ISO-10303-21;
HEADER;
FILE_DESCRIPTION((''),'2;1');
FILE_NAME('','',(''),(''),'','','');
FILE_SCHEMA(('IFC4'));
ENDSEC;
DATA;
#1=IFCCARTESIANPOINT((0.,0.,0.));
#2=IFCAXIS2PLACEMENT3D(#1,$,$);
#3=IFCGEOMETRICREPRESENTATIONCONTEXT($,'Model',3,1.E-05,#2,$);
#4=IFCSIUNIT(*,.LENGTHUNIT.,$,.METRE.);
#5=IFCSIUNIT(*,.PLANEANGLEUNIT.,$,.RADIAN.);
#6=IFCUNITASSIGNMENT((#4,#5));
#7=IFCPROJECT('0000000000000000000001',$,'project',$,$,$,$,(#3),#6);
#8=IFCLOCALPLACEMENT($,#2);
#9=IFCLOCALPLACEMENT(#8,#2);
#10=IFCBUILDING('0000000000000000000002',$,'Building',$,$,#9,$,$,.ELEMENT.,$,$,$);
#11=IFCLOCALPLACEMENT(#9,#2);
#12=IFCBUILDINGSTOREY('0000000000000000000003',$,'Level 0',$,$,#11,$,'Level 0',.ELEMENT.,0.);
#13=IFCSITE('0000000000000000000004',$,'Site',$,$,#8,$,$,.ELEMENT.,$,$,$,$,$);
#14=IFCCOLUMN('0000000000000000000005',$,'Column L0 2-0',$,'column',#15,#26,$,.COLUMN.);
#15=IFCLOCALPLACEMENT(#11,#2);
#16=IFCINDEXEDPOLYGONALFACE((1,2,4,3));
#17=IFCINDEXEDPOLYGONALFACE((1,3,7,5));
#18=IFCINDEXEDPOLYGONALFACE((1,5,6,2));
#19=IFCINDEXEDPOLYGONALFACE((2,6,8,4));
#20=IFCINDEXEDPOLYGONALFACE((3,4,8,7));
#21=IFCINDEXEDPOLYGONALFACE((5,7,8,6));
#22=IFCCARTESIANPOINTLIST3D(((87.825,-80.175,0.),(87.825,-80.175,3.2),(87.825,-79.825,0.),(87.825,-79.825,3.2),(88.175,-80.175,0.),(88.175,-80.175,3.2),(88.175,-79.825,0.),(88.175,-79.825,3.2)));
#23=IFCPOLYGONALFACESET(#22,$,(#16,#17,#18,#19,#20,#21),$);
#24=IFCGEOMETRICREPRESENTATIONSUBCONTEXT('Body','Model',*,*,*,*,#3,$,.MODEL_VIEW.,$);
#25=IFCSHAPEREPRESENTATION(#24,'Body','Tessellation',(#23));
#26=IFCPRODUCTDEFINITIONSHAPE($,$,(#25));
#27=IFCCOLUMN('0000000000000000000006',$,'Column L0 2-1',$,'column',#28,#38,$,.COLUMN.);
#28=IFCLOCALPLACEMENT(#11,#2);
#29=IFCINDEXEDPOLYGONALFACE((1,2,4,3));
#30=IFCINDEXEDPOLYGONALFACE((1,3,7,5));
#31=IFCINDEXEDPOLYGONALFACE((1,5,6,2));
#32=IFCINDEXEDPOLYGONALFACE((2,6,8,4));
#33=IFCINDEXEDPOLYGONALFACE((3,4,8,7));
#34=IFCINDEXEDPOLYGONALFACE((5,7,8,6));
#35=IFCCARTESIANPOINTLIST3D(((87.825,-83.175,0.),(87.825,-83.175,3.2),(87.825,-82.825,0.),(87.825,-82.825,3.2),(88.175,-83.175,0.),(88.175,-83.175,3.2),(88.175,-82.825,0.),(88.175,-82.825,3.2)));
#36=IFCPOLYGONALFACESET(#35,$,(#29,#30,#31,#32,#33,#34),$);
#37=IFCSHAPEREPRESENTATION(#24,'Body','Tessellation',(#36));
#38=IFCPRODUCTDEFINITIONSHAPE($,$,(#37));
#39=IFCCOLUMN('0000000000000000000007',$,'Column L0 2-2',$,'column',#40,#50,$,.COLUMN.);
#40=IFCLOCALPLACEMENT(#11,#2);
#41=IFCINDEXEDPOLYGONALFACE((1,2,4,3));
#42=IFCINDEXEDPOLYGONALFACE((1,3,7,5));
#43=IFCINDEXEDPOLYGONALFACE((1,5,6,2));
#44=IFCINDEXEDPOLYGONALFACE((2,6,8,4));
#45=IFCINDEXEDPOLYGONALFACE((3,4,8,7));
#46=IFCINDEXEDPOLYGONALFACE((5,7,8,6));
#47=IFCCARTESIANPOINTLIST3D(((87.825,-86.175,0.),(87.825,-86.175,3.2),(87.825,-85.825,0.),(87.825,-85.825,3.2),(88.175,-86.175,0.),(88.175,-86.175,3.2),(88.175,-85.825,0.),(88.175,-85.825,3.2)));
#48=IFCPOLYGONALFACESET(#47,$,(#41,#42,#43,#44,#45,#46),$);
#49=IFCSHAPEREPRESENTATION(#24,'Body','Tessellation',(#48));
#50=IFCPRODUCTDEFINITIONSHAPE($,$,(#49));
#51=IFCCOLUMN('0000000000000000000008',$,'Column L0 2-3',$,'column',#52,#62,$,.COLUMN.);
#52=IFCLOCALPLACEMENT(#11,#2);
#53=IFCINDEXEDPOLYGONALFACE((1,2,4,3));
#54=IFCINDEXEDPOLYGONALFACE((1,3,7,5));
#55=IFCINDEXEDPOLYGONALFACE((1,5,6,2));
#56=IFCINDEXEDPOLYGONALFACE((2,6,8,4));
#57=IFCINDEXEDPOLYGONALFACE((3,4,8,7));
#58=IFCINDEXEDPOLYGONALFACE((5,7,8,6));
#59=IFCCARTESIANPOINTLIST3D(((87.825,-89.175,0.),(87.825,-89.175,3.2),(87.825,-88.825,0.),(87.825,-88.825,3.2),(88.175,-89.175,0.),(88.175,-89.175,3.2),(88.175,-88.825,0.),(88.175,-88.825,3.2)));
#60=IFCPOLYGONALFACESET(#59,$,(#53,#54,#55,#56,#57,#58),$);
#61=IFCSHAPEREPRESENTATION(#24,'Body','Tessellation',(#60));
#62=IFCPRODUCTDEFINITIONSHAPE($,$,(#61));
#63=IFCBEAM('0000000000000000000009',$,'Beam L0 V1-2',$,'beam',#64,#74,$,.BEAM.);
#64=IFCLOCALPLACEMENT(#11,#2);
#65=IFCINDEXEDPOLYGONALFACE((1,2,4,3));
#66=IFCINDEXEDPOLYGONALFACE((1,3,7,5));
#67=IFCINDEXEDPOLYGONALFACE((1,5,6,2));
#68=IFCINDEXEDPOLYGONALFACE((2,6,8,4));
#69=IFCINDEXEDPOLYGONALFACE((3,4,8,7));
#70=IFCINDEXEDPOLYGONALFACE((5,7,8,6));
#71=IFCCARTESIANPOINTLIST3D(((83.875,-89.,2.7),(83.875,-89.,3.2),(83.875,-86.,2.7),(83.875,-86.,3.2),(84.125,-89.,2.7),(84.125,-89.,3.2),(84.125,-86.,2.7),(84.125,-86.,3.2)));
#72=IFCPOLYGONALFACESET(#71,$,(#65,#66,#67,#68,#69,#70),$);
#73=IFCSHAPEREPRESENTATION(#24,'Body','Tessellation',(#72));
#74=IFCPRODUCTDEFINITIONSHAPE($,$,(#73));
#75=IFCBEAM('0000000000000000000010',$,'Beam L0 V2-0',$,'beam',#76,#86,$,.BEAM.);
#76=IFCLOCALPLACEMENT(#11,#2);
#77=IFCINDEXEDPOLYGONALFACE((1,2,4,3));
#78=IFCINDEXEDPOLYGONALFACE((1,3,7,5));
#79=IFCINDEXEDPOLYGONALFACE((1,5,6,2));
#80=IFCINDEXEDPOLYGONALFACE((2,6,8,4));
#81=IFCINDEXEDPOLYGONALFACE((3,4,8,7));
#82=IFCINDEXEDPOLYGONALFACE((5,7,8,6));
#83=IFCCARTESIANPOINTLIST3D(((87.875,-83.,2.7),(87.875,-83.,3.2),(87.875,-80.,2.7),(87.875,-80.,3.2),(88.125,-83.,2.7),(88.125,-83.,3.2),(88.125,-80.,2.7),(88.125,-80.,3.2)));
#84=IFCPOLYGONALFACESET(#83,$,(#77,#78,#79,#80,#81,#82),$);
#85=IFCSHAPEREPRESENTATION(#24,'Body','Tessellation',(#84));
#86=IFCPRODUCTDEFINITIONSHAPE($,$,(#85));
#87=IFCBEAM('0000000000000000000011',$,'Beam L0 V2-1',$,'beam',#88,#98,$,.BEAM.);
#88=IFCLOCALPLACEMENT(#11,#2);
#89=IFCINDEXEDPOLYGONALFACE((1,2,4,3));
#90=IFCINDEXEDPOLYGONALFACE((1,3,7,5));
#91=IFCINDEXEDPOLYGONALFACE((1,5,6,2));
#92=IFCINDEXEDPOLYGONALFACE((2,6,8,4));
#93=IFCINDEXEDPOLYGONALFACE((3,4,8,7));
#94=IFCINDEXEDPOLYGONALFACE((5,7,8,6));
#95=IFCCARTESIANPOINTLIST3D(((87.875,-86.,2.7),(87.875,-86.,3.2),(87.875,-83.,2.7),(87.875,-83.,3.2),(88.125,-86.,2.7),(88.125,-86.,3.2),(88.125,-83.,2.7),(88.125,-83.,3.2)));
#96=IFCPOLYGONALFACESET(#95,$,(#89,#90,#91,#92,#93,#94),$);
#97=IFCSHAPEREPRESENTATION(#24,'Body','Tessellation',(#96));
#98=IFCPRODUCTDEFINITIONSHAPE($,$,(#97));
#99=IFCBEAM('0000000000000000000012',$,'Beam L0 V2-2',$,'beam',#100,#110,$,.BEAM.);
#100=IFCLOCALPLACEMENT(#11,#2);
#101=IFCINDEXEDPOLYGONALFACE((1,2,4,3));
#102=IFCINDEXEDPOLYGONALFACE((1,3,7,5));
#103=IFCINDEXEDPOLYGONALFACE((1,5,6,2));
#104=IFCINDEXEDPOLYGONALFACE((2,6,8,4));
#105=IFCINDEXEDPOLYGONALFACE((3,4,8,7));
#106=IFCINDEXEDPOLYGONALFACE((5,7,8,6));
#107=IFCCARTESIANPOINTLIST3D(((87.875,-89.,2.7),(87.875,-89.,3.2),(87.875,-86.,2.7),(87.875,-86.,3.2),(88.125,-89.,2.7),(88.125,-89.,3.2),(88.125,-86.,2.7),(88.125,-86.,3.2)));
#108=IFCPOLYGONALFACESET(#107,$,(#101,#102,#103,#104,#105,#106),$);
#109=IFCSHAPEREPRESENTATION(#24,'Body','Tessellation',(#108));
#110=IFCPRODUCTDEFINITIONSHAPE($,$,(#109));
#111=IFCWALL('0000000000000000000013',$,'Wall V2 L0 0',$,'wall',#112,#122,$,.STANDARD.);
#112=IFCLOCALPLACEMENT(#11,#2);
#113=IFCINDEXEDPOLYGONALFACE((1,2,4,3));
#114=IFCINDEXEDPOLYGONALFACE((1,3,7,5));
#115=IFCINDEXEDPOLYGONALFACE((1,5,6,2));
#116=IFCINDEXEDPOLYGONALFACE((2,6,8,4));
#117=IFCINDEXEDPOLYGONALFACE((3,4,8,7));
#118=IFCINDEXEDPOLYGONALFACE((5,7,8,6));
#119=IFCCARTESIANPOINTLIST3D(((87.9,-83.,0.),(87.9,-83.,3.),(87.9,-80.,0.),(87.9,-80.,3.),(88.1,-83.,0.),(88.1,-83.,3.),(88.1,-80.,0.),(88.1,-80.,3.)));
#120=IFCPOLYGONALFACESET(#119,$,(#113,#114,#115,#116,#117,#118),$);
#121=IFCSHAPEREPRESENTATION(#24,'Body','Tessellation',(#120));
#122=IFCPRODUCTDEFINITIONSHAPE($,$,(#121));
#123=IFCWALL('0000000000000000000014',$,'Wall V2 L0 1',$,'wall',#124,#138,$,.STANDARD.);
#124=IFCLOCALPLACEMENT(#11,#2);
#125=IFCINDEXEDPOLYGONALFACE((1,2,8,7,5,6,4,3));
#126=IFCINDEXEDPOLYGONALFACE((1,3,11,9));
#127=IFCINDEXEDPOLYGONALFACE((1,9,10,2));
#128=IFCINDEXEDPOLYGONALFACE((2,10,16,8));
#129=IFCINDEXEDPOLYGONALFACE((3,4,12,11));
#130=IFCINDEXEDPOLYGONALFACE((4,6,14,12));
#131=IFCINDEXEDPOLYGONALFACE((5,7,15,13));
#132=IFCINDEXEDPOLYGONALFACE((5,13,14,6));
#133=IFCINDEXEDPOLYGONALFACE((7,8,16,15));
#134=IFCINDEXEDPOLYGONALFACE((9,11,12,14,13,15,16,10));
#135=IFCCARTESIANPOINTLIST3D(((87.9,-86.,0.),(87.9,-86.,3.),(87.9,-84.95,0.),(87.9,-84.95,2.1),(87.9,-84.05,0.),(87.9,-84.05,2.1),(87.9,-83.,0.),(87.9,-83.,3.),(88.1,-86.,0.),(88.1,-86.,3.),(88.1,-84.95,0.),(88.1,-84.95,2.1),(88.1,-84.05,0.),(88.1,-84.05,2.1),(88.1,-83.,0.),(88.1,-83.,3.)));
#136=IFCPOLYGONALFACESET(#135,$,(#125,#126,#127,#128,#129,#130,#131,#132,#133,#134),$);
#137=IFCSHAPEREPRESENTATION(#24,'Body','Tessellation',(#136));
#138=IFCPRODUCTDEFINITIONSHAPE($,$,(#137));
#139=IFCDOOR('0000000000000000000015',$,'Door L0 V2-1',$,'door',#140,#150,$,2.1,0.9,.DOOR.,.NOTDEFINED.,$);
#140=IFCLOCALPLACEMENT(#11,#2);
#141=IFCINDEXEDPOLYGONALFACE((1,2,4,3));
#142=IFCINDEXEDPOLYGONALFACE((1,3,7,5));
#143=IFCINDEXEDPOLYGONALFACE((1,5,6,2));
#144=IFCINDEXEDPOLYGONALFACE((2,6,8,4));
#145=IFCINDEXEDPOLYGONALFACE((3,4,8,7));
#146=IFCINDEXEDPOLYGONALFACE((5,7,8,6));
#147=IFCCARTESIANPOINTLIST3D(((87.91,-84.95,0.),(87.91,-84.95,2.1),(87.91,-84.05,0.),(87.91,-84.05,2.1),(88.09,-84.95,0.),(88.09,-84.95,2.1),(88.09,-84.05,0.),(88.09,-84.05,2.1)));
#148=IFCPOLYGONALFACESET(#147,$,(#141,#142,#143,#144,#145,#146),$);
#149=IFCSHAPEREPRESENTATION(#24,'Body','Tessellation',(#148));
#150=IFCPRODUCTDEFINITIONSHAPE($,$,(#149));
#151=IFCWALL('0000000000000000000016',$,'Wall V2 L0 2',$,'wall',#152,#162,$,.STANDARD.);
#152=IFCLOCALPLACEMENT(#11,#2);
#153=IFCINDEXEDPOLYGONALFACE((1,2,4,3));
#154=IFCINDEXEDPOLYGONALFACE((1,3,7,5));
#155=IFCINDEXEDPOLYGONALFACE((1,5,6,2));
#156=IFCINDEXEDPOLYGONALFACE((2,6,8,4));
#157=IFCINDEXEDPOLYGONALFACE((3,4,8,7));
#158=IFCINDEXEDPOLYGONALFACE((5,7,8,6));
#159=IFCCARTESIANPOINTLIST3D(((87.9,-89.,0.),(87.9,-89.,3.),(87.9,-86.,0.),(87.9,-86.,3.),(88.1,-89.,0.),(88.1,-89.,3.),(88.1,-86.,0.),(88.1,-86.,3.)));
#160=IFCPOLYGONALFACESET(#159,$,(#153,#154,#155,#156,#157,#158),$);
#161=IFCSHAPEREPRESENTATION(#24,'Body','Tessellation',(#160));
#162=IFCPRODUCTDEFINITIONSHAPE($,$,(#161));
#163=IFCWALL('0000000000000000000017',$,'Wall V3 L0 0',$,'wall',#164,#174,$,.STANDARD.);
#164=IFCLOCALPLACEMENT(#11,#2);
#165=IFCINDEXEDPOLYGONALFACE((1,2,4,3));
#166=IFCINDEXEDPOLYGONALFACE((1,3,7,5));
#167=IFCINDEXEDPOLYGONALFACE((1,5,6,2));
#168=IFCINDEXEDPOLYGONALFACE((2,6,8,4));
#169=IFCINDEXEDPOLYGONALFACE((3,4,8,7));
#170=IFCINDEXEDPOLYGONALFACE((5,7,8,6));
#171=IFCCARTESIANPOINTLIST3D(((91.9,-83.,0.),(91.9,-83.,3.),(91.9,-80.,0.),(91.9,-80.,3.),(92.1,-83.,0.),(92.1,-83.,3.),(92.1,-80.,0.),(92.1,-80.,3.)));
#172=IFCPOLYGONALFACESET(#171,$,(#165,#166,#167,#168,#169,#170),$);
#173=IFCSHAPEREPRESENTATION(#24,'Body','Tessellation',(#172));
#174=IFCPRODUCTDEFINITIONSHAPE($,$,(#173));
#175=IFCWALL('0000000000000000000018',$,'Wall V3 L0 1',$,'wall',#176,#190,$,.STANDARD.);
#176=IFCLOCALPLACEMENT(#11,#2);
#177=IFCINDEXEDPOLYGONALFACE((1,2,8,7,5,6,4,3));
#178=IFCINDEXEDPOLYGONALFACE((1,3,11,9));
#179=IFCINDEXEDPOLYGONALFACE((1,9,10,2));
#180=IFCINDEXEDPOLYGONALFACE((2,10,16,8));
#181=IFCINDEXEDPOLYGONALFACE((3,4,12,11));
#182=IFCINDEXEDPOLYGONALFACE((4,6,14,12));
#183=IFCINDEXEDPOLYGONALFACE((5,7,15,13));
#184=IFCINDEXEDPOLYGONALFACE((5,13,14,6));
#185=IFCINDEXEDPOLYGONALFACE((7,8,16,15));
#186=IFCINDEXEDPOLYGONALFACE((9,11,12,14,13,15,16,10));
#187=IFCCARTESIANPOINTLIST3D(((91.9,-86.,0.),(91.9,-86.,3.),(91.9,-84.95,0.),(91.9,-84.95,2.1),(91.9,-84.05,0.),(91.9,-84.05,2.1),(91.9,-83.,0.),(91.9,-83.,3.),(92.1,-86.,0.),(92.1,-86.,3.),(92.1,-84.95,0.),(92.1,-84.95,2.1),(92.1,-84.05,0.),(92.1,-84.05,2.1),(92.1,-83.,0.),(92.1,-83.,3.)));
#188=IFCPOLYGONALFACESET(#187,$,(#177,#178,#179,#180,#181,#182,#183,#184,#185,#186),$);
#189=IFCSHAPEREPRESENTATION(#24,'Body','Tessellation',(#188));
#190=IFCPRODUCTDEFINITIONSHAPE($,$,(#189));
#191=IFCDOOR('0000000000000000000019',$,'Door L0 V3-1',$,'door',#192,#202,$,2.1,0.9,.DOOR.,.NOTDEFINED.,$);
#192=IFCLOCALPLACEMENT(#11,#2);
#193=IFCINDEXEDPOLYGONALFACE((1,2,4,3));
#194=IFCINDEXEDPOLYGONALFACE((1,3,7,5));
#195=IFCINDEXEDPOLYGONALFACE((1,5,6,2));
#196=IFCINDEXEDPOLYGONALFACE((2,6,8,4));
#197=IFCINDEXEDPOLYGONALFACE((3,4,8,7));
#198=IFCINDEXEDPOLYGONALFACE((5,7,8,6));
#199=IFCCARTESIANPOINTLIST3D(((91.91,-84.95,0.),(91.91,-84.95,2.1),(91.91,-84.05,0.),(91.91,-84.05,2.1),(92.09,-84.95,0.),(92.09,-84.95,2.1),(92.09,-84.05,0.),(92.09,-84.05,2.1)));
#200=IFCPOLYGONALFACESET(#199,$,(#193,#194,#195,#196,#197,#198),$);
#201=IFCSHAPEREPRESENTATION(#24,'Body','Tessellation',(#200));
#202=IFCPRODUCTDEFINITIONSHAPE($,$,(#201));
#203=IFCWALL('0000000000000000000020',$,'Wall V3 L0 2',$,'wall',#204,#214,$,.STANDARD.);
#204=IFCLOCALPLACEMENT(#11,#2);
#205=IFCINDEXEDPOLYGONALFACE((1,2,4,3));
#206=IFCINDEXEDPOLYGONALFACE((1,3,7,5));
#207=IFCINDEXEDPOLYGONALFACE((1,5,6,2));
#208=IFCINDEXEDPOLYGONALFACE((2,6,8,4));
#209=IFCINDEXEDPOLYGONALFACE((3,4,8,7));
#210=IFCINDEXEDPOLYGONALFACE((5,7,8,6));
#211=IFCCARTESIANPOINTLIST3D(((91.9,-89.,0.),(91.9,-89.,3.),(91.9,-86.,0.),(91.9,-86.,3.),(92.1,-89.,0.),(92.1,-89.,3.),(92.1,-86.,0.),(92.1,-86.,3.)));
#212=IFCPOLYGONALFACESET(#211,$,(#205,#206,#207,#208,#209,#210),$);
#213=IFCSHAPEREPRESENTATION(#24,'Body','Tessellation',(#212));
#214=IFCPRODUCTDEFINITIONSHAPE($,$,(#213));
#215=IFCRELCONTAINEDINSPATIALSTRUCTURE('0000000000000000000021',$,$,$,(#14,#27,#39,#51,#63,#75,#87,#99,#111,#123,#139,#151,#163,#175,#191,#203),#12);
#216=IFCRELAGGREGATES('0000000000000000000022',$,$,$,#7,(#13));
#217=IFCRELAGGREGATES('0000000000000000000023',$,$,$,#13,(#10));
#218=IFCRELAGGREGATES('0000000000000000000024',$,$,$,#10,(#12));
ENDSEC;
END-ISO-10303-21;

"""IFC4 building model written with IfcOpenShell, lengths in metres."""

from ifc_helpers import new_model, si_unit, frame, frame_2d, origin, origin_2d, place, context, subcontext, project, spatial, rectangle, extrude, element, fill, save


model = new_model("IFC4")

# Units and contexts
model_context = context("Model", 3, precision=1e-05, world=origin())
body_context = subcontext(model_context, "Body", "Model", "MODEL_VIEW")
ifc_project = project(units=[si_unit("LENGTHUNIT", "METRE"), si_unit("PLANEANGLEUNIT", "RADIAN")], contexts=[model_context])

# Site, building, storey
site_placement = place(None, origin())
site = spatial("IfcSite", under=ifc_project, at=site_placement, Name="Site", CompositionType="ELEMENT")
building_placement = place(site_placement, origin())
building = spatial("IfcBuilding", under=site, at=building_placement, Name="Building", CompositionType="ELEMENT")
storey_placement = place(building_placement, origin())
storey = spatial("IfcBuildingStorey", under=building, at=storey_placement, Name="Level 0", LongName="Level 0", CompositionType="ELEMENT", Elevation=0.0)

# Columns
for number, where, name in (
    (1, (88.0, -80.0, 0.0), "Column L0 2-0"),
    (2, (88.0, -83.0, 0.0), "Column L0 2-1"),
    (3, (88.0, -86.0, 0.0), "Column L0 2-2"),
    (4, (88.0, -89.0, 0.0), "Column L0 2-3"),
):
    element("IfcColumn", number, at=place(storey_placement, frame(where)), inside=storey, Name=name, ObjectType="column", PredefinedType="COLUMN", context=body_context, shape_type="SweptSolid", body=[
        extrude(rectangle(XDim=0.35, YDim=0.35, at=origin_2d()), origin(), (0.0, 0.0, 1.0), 3.2),
    ])

# Beams
for number, where, z_axis, x_axis, name in (
    (5, (84.0, -86.0, 2.95), (0.0, -1.0, 0.0), (0.0, 0.0, 1.0), "Beam L0 V1-2"),
    (6, (88.0, -80.0, 2.95), (0.0, -1.0, 0.0), (0.0, 0.0, 1.0), "Beam L0 V2-0"),
    (7, (88.0, -83.0, 2.95), (0.0, -1.0, 0.0), (0.0, 0.0, 1.0), "Beam L0 V2-1"),
    (8, (88.0, -86.0, 2.95), (0.0, -1.0, 0.0), (0.0, 0.0, 1.0), "Beam L0 V2-2"),
):
    element("IfcBeam", number, at=place(storey_placement, frame(where, z_axis=z_axis, x_axis=x_axis)), inside=storey, Name=name, ObjectType="beam", PredefinedType="BEAM", context=body_context, shape_type="SweptSolid", body=[
        extrude(rectangle(XDim=0.5, YDim=0.25, at=origin_2d()), origin(), (0.0, 0.0, 1.0), 3.0),
    ])

# Wall
wall_1_placement = place(storey_placement, frame((88.0, -80.0, 0.0), z_axis=(0.0, 0.0, 1.0), x_axis=(0.0, -1.0, 0.0)))
element("IfcWall", 9, at=wall_1_placement, inside=storey, Name="Wall V2 L0 0", ObjectType="wall", PredefinedType="STANDARD", context=body_context, shape_type="SweptSolid", body=[
    extrude(rectangle(XDim=3.0, YDim=0.2, at=frame_2d((1.5, 0.0))), origin(), (0.0, 0.0, 1.0), 3.0),
])

# Wall, opening, door
wall_2_placement = place(storey_placement, frame((88.0, -83.0, 0.0), z_axis=(0.0, 0.0, 1.0), x_axis=(0.0, -1.0, 0.0)))
wall_2 = element("IfcWall", 10, at=wall_2_placement, inside=storey, Name="Wall V2 L0 1", ObjectType="wall", PredefinedType="STANDARD", context=body_context, shape_type="SweptSolid", body=[
    extrude(rectangle(XDim=3.0, YDim=0.2, at=frame_2d((1.5, 0.0))), origin(), (0.0, 0.0, 1.0), 3.0),
])
opening_1_placement = place(storey_placement, frame((88.0, -84.5, 0.0), z_axis=(0.0, 0.0, 1.0), x_axis=(0.0, -1.0, 0.0)))
opening_1 = element("IfcOpeningElement", 11, at=opening_1_placement, cuts=wall_2, ObjectType="Opening", PredefinedType="OPENING", context=body_context, shape_type="SweptSolid", body=[
    extrude(rectangle(XDim=0.9, YDim=0.22, at=origin_2d()), origin(), (0.0, 0.0, 1.0), 2.1),
])
door_1_placement = place(storey_placement, frame((88.0, -84.5, 0.0), z_axis=(0.0, 0.0, 1.0), x_axis=(0.0, -1.0, 0.0)))
door_1 = element("IfcDoor", 12, at=door_1_placement, inside=storey, Name="Door L0 V2-1", ObjectType="door", OperationType="NOTDEFINED", OverallHeight=2.1, OverallWidth=0.9, PredefinedType="DOOR", context=body_context, shape_type="SweptSolid", body=[
    extrude(rectangle(XDim=0.9, YDim=0.18, at=origin_2d()), origin(), (0.0, 0.0, 1.0), 2.1),
])
fill(opening_1, door_1)

# Walls
for number, where, z_axis, x_axis, name in (
    (13, (88.0, -86.0, 0.0), (0.0, 0.0, 1.0), (0.0, -1.0, 0.0), "Wall V2 L0 2"),
    (14, (92.0, -80.0, 0.0), (0.0, 0.0, 1.0), (0.0, -1.0, 0.0), "Wall V3 L0 0"),
):
    element("IfcWall", number, at=place(storey_placement, frame(where, z_axis=z_axis, x_axis=x_axis)), inside=storey, Name=name, ObjectType="wall", PredefinedType="STANDARD", context=body_context, shape_type="SweptSolid", body=[
        extrude(rectangle(XDim=3.0, YDim=0.2, at=frame_2d((1.5, 0.0))), origin(), (0.0, 0.0, 1.0), 3.0),
    ])

# Wall, opening, door
wall_3_placement = place(storey_placement, frame((92.0, -83.0, 0.0), z_axis=(0.0, 0.0, 1.0), x_axis=(0.0, -1.0, 0.0)))
wall_3 = element("IfcWall", 15, at=wall_3_placement, inside=storey, Name="Wall V3 L0 1", ObjectType="wall", PredefinedType="STANDARD", context=body_context, shape_type="SweptSolid", body=[
    extrude(rectangle(XDim=3.0, YDim=0.2, at=frame_2d((1.5, 0.0))), origin(), (0.0, 0.0, 1.0), 3.0),
])
opening_2_placement = place(storey_placement, frame((92.0, -84.5, 0.0), z_axis=(0.0, 0.0, 1.0), x_axis=(0.0, -1.0, 0.0)))
opening_2 = element("IfcOpeningElement", 16, at=opening_2_placement, cuts=wall_3, ObjectType="Opening", PredefinedType="OPENING", context=body_context, shape_type="SweptSolid", body=[
    extrude(rectangle(XDim=0.9, YDim=0.22, at=origin_2d()), origin(), (0.0, 0.0, 1.0), 2.1),
])
door_2_placement = place(storey_placement, frame((92.0, -84.5, 0.0), z_axis=(0.0, 0.0, 1.0), x_axis=(0.0, -1.0, 0.0)))
door_2 = element("IfcDoor", 17, at=door_2_placement, inside=storey, Name="Door L0 V3-1", ObjectType="door", OperationType="NOTDEFINED", OverallHeight=2.1, OverallWidth=0.9, PredefinedType="DOOR", context=body_context, shape_type="SweptSolid", body=[
    extrude(rectangle(XDim=0.9, YDim=0.18, at=origin_2d()), origin(), (0.0, 0.0, 1.0), 2.1),
])
fill(opening_2, door_2)

# Wall
wall_4_placement = place(storey_placement, frame((92.0, -86.0, 0.0), z_axis=(0.0, 0.0, 1.0), x_axis=(0.0, -1.0, 0.0)))
element("IfcWall", 18, at=wall_4_placement, inside=storey, Name="Wall V3 L0 2", ObjectType="wall", PredefinedType="STANDARD", context=body_context, shape_type="SweptSolid", body=[
    extrude(rectangle(XDim=3.0, YDim=0.2, at=frame_2d((1.5, 0.0))), origin(), (0.0, 0.0, 1.0), 3.0),
])

save(model, "model.ifc")
